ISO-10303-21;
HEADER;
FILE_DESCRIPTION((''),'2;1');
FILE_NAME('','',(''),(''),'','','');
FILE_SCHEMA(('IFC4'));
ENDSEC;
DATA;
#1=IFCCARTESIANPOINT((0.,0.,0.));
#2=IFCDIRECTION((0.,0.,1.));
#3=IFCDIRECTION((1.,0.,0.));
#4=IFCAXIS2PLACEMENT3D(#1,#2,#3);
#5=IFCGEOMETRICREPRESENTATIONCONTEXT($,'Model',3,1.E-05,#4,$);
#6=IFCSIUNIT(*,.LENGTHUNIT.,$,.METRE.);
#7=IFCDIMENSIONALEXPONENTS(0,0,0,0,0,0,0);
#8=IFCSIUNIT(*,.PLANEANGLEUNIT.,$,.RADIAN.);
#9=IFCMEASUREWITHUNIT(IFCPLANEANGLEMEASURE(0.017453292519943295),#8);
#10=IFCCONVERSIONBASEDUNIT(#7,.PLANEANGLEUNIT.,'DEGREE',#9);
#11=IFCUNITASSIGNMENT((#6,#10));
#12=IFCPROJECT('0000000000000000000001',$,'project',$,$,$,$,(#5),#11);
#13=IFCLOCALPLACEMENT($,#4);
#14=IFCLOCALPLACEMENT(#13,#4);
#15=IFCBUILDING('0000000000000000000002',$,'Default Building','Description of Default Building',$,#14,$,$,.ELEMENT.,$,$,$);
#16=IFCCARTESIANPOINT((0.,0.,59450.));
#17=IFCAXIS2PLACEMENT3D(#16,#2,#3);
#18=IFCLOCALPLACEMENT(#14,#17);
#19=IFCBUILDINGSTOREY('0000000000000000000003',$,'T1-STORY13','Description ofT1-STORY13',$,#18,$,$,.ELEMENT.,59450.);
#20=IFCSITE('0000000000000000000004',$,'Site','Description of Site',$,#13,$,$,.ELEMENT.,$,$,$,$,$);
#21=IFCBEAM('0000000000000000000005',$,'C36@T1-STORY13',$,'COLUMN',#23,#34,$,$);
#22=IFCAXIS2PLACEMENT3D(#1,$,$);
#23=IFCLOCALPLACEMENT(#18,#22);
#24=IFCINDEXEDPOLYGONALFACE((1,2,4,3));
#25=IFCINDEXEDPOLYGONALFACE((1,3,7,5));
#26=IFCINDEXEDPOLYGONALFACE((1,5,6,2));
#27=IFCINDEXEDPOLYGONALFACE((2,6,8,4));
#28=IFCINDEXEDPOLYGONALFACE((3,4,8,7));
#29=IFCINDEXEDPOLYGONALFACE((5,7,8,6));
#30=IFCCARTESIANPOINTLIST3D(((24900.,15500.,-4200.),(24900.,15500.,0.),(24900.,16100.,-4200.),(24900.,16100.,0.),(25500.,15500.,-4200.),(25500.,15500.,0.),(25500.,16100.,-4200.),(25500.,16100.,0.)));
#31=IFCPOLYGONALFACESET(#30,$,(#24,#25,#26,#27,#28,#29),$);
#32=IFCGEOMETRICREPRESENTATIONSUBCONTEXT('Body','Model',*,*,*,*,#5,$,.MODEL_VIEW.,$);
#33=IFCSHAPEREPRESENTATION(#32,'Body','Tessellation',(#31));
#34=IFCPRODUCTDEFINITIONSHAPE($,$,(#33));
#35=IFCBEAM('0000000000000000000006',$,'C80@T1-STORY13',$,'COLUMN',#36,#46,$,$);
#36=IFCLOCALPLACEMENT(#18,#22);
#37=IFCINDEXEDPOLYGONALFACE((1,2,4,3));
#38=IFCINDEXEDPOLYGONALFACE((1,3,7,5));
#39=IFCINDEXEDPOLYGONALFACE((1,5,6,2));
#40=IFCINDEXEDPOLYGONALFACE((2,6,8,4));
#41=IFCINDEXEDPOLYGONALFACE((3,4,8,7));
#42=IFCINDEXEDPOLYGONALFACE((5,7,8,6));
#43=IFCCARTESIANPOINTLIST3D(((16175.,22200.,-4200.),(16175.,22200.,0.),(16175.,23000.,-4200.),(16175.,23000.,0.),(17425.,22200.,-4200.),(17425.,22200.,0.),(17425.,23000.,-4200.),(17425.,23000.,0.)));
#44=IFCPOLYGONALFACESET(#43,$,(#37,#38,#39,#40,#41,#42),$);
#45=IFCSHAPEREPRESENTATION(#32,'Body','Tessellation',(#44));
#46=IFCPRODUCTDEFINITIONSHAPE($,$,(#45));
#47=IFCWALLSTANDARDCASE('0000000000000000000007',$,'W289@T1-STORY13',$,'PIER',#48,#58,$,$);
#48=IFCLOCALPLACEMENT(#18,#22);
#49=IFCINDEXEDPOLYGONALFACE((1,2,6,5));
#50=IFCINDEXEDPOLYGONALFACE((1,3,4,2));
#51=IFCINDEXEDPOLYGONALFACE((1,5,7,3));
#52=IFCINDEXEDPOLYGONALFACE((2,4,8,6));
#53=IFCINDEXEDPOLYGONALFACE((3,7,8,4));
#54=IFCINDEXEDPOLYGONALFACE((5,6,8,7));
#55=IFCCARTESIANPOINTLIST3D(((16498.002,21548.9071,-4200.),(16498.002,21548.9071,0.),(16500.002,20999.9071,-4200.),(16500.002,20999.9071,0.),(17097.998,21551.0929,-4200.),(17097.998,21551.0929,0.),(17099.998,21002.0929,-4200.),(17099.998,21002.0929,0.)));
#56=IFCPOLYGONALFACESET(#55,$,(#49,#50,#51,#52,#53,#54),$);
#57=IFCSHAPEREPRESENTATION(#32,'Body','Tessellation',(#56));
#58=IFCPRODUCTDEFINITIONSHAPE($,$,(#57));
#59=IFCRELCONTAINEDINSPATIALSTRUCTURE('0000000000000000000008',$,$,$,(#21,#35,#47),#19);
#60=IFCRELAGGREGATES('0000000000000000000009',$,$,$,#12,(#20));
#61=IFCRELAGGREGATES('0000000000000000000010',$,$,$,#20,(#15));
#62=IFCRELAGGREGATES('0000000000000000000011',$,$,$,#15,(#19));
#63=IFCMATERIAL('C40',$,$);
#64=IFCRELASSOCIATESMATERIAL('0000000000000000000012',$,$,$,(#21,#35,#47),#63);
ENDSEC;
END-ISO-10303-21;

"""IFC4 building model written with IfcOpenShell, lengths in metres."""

from ifc_helpers import new_model, entity, si_unit, converted_unit, frame, origin_with_axes, place, context, subcontext, project, spatial, indexed_curve, rectangle, outline, extrude, material, element, save


model = new_model("IFC4")

# Units and contexts
model_context = context("Model", 3, precision=1e-05, world=origin_with_axes())
body_context = subcontext(model_context, "Body", "Model", "MODEL_VIEW")
ifc_project = project(units=[si_unit("LENGTHUNIT", "METRE"), converted_unit("PLANEANGLEUNIT", "DEGREE", entity("IfcPlaneAngleMeasure", 0.017453292519943295), si_unit("PLANEANGLEUNIT", "RADIAN"), dimensions=[0, 0, 0, 0, 0, 0, 0])], contexts=[model_context])

# Site, building, storey
site_placement = place(None, origin_with_axes())
site = spatial("IfcSite", under=ifc_project, at=site_placement, Name="Site", Description="Description of Site", CompositionType="ELEMENT")
building_placement = place(site_placement, origin_with_axes())
building = spatial("IfcBuilding", under=site, at=building_placement, Name="Default Building", Description="Description of Default Building", CompositionType="ELEMENT")
storey_placement = place(building_placement, frame((0.0, 0.0, 59450.0), z_axis=(0.0, 0.0, 1.0), x_axis=(1.0, 0.0, 0.0)))
storey = spatial("IfcBuildingStorey", under=building, at=storey_placement, Name="T1-STORY13", Description="Description ofT1-STORY13", CompositionType="ELEMENT", Elevation=59450.0)

# Beams
ifc_material_1 = material(Name="C40")
beam_1_placement = place(storey_placement, frame((25200.0, 15800.0, -4200.0), z_axis=(0.0, 0.0, 1.0), x_axis=(-1.0, 0.0, 0.0)))
element("IfcBeam", 1, at=beam_1_placement, inside=storey, material=ifc_material_1, Name="C36@T1-STORY13", ObjectType="COLUMN", context=body_context, shape_type="SweptSolid", body=[
    extrude(rectangle(XDim=600.0, YDim=600.0), origin_with_axes(), (0.0, 0.0, 1.0), 4200.0),
])
beam_2_placement = place(storey_placement, frame((16800.0, 22600.0, -4200.0), z_axis=(0.0, 0.0, 1.0), x_axis=(0.0, -1.0, 0.0)))
element("IfcBeam", 2, at=beam_2_placement, inside=storey, material=ifc_material_1, Name="C80@T1-STORY13", ObjectType="COLUMN", context=body_context, shape_type="SweptSolid", body=[
    extrude(rectangle(XDim=800.0, YDim=1250.0), origin_with_axes(), (0.0, 0.0, 1.0), 4200.0),
])

# Wall
wall_placement = place(storey_placement, frame((16800.0, 21001.0, -4200.0), z_axis=(0.0, 0.0, 1.0), x_axis=(-0.003643, 0.999993, 0.0)))
element("IfcWallStandardCase", 3, at=wall_placement, inside=storey, material=ifc_material_1, Name="W289@T1-STORY13", ObjectType="PIER", context=body_context, shape_type="SweptSolid", body=[
    extrude(outline(indexed_curve([(0.0, -300.0), (0.0, 300.0), (549.0036, 300.0), (549.0036, -300.0), (0.0, -300.0)], self_intersect=False)), origin_with_axes(), (0.0, 0.0, 1.0), 4200.0),
])

save(model, "model.ifc")
